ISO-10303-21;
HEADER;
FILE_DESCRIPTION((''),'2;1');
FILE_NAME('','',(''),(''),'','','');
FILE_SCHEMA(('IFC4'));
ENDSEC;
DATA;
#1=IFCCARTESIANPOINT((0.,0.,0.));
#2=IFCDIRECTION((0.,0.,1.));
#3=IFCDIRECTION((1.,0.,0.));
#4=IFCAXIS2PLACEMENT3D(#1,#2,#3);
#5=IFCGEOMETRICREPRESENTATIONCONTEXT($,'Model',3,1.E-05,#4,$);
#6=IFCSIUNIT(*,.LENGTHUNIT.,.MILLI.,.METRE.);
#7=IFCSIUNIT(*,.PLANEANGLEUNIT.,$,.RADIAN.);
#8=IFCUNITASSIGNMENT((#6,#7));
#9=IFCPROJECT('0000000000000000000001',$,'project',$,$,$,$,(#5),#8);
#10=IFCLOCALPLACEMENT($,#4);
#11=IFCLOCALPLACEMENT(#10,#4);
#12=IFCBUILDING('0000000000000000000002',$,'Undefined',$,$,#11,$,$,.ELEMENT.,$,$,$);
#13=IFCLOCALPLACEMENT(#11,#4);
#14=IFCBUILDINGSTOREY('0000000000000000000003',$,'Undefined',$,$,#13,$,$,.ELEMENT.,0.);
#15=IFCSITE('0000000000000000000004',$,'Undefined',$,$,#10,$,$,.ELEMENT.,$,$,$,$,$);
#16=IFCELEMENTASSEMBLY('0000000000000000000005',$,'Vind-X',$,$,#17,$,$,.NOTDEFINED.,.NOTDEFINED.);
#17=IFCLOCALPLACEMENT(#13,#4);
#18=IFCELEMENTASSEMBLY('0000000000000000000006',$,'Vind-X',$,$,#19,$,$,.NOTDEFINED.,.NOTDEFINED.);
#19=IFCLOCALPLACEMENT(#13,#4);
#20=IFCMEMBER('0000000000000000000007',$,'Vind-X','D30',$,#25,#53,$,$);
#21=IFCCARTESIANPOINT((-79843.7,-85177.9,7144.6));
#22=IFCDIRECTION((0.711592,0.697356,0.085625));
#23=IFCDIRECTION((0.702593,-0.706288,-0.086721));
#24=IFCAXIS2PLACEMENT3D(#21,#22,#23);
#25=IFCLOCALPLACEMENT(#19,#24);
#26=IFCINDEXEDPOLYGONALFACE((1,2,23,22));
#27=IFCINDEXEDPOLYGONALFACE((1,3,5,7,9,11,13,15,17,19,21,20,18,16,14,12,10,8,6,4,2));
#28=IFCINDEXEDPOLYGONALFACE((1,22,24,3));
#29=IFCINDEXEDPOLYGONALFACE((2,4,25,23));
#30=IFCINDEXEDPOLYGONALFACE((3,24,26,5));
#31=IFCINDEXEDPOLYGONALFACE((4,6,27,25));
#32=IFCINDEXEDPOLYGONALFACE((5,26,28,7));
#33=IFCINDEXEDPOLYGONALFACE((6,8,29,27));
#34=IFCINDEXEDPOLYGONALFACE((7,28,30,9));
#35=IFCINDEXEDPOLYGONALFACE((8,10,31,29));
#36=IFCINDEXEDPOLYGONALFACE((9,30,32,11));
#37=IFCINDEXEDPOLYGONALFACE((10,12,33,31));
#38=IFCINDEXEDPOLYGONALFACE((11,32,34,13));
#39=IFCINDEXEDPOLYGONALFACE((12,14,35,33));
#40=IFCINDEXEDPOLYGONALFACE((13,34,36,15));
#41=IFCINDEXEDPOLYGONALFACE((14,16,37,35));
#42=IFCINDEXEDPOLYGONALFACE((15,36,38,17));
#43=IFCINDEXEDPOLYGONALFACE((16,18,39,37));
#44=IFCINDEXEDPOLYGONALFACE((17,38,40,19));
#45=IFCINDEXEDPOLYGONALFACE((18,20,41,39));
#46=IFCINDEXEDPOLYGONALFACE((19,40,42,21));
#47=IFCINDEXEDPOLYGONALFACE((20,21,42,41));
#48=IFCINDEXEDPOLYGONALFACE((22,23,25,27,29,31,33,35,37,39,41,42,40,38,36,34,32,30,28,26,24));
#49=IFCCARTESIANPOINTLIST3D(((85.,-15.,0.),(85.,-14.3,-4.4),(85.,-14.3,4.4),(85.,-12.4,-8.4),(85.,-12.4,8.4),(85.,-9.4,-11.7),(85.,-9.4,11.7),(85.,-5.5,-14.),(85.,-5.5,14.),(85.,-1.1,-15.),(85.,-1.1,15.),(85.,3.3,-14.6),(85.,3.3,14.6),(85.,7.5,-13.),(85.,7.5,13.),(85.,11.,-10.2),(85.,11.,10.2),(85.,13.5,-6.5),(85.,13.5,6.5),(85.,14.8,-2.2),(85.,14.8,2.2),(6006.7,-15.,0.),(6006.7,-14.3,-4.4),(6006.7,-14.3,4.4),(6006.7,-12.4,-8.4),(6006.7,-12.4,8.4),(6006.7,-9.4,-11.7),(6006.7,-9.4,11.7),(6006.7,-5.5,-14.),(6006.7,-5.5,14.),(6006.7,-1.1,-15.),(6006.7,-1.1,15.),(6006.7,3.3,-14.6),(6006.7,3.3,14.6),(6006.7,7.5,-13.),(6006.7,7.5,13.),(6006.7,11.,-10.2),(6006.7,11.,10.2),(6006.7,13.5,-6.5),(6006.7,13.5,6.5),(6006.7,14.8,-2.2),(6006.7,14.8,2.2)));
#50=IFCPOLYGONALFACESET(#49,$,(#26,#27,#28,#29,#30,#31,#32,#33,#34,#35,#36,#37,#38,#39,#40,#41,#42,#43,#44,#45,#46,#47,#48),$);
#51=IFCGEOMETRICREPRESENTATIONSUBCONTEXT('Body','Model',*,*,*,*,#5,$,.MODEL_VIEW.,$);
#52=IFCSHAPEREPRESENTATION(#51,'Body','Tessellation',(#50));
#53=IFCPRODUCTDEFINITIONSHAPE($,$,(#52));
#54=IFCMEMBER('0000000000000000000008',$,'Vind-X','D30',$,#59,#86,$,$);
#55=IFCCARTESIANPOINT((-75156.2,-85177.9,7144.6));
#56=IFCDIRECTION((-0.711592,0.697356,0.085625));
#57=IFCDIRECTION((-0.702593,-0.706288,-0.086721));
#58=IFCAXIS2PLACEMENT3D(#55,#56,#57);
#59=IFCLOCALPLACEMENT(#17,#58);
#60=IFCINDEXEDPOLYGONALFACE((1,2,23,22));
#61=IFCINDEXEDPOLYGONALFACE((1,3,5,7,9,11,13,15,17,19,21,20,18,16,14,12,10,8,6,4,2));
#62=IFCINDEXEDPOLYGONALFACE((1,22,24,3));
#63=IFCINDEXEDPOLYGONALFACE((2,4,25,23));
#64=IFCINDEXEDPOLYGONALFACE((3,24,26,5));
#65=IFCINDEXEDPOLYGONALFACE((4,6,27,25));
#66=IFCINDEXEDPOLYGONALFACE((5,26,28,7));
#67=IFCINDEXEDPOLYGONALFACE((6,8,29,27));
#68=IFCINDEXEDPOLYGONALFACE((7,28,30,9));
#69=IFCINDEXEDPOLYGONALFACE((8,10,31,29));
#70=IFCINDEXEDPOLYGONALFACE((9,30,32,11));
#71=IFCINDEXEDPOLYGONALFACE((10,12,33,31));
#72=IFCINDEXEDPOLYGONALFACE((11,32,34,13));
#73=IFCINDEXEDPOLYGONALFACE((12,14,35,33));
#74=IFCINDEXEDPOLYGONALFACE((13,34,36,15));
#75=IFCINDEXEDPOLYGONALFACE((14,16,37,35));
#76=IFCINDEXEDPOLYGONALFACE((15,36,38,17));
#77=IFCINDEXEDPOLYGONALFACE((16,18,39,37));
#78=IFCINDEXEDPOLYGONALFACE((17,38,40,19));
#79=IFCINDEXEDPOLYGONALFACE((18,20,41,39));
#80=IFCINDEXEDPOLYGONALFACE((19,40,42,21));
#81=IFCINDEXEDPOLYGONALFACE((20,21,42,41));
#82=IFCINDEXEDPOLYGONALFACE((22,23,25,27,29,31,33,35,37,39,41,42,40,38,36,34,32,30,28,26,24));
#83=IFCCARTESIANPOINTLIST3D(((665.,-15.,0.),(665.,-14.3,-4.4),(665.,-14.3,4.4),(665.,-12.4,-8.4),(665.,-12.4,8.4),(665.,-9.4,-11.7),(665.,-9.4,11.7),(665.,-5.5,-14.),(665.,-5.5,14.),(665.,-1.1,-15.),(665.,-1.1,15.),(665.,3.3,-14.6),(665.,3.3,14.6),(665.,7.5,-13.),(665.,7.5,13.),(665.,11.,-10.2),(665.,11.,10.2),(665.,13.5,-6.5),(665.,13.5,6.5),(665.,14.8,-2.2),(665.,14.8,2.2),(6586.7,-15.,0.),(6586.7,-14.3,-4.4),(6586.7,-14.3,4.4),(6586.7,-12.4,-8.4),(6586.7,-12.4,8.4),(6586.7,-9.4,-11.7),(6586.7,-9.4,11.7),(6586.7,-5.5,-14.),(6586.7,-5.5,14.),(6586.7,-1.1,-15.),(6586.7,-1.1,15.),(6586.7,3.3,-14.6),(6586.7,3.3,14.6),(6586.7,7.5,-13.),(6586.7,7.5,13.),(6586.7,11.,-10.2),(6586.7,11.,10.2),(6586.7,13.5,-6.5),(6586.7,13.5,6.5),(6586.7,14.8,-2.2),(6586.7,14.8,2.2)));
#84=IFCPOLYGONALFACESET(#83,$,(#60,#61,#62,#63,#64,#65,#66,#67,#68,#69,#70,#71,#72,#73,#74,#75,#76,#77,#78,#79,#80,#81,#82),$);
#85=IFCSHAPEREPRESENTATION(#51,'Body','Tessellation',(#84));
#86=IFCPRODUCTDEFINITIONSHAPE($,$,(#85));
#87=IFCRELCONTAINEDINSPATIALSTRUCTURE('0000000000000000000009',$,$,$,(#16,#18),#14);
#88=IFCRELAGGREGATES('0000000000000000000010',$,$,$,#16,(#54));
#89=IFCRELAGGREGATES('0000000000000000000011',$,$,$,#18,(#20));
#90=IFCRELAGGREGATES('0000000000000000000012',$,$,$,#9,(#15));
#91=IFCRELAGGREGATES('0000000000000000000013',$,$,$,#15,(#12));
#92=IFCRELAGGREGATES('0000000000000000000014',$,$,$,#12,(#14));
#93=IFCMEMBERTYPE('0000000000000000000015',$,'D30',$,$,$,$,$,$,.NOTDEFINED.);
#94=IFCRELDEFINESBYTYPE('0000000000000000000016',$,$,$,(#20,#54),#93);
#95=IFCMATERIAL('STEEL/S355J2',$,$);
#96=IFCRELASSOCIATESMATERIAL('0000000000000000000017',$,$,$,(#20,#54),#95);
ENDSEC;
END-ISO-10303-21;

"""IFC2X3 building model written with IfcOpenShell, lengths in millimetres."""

from ifc_helpers import new_model, si_unit, frame, origin_with_axes, origin_2d_with_axis, place, context, subcontext, project, spatial, circle, extrude, clip, halfspace, material, type_object, element, aggregate, save


model = new_model("IFC2X3")

# Units and contexts
model_context = context("Model", 3, precision=1e-05, world=origin_with_axes())
body_context = subcontext(model_context, "Body", "Model", "MODEL_VIEW")
ifc_project = project(units=[si_unit("LENGTHUNIT", "METRE", prefix="MILLI"), si_unit("PLANEANGLEUNIT", "RADIAN")], contexts=[model_context])

# Site, building, storey
site_placement = place(None, origin_with_axes())
site = spatial("IfcSite", under=ifc_project, at=site_placement, Name="Undefined", CompositionType="ELEMENT")
building_placement = place(site_placement, origin_with_axes())
building = spatial("IfcBuilding", under=site, at=building_placement, Name="Undefined", CompositionType="ELEMENT")
storey_placement = place(building_placement, origin_with_axes())
storey = spatial("IfcBuildingStorey", under=building, at=storey_placement, Name="Undefined", CompositionType="ELEMENT", Elevation=0.0)

# Element assembly
assembly_1_placement = place(storey_placement, origin_with_axes())
assembly_1 = element("IfcElementAssembly", 1, at=assembly_1_placement, inside=storey, Name="Vind-X", AssemblyPlace="NOTDEFINED", PredefinedType="NOTDEFINED")
ifc_material_1 = material(Name="STEEL/S355J2")

# Element assembly, member
assembly_2_placement = place(storey_placement, origin_with_axes())
assembly_2 = element("IfcElementAssembly", 2, at=assembly_2_placement, inside=storey, Name="Vind-X", AssemblyPlace="NOTDEFINED", PredefinedType="NOTDEFINED")
member_type = type_object("IfcMemberType", Name="D30", PredefinedType="NOTDEFINED")
member_1_placement = place(assembly_2_placement, frame((-79843.7, -85177.9, 7144.6), z_axis=(0.711592, 0.697356, 0.085625), x_axis=(0.702593, -0.706288, -0.086721)))
member_1 = element("IfcMember", 3, at=member_1_placement, type_object=member_type, material=ifc_material_1, Name="Vind-X", Description="D30", context=body_context, shape_type="Clipping", body=[
    clip(clip(extrude(circle(Radius=15.0, at=origin_2d_with_axis()), frame((6671.7, 0.0, 0.0), z_axis=(-1.0, 0.0, 0.0), x_axis=(0.0, -1.0, 0.0)), (0.0, 0.0, 1.0), 6671.7), halfspace(frame((6006.7, -6.0, 10.2), z_axis=(1.0, 0.0, 0.0), x_axis=(0.0, 1.0, 0.0)), False)), halfspace(frame((85.0, -6.0, 16.0), z_axis=(1.0, 0.0, 0.0), x_axis=(0.0, 1.0, 0.0)), True)),
])

# Member
member_2_placement = place(assembly_1_placement, frame((-75156.2, -85177.9, 7144.6), z_axis=(-0.711592, 0.697356, 0.085625), x_axis=(-0.702593, -0.706288, -0.086721)))
member_2 = element("IfcMember", 4, at=member_2_placement, type_object=member_type, material=ifc_material_1, Name="Vind-X", Description="D30", context=body_context, shape_type="Clipping", body=[
    clip(clip(extrude(circle(Radius=15.0, at=origin_2d_with_axis()), frame((6671.7, 0.0, 0.0), z_axis=(-1.0, 0.0, 0.0), x_axis=(0.0, -1.0, 0.0)), (0.0, 0.0, 1.0), 6671.7), halfspace(frame((6586.7, 6.0, 16.0), z_axis=(-1.0, 0.0, 0.0), x_axis=(0.0, -1.0, 0.0)), True)), halfspace(frame((665.0, 6.0, 10.2), z_axis=(-1.0, 0.0, 0.0), x_axis=(0.0, -1.0, 0.0)), False)),
])

aggregate(assembly_1, [member_2])
aggregate(assembly_2, [member_1])

save(model, "model.ifc")
